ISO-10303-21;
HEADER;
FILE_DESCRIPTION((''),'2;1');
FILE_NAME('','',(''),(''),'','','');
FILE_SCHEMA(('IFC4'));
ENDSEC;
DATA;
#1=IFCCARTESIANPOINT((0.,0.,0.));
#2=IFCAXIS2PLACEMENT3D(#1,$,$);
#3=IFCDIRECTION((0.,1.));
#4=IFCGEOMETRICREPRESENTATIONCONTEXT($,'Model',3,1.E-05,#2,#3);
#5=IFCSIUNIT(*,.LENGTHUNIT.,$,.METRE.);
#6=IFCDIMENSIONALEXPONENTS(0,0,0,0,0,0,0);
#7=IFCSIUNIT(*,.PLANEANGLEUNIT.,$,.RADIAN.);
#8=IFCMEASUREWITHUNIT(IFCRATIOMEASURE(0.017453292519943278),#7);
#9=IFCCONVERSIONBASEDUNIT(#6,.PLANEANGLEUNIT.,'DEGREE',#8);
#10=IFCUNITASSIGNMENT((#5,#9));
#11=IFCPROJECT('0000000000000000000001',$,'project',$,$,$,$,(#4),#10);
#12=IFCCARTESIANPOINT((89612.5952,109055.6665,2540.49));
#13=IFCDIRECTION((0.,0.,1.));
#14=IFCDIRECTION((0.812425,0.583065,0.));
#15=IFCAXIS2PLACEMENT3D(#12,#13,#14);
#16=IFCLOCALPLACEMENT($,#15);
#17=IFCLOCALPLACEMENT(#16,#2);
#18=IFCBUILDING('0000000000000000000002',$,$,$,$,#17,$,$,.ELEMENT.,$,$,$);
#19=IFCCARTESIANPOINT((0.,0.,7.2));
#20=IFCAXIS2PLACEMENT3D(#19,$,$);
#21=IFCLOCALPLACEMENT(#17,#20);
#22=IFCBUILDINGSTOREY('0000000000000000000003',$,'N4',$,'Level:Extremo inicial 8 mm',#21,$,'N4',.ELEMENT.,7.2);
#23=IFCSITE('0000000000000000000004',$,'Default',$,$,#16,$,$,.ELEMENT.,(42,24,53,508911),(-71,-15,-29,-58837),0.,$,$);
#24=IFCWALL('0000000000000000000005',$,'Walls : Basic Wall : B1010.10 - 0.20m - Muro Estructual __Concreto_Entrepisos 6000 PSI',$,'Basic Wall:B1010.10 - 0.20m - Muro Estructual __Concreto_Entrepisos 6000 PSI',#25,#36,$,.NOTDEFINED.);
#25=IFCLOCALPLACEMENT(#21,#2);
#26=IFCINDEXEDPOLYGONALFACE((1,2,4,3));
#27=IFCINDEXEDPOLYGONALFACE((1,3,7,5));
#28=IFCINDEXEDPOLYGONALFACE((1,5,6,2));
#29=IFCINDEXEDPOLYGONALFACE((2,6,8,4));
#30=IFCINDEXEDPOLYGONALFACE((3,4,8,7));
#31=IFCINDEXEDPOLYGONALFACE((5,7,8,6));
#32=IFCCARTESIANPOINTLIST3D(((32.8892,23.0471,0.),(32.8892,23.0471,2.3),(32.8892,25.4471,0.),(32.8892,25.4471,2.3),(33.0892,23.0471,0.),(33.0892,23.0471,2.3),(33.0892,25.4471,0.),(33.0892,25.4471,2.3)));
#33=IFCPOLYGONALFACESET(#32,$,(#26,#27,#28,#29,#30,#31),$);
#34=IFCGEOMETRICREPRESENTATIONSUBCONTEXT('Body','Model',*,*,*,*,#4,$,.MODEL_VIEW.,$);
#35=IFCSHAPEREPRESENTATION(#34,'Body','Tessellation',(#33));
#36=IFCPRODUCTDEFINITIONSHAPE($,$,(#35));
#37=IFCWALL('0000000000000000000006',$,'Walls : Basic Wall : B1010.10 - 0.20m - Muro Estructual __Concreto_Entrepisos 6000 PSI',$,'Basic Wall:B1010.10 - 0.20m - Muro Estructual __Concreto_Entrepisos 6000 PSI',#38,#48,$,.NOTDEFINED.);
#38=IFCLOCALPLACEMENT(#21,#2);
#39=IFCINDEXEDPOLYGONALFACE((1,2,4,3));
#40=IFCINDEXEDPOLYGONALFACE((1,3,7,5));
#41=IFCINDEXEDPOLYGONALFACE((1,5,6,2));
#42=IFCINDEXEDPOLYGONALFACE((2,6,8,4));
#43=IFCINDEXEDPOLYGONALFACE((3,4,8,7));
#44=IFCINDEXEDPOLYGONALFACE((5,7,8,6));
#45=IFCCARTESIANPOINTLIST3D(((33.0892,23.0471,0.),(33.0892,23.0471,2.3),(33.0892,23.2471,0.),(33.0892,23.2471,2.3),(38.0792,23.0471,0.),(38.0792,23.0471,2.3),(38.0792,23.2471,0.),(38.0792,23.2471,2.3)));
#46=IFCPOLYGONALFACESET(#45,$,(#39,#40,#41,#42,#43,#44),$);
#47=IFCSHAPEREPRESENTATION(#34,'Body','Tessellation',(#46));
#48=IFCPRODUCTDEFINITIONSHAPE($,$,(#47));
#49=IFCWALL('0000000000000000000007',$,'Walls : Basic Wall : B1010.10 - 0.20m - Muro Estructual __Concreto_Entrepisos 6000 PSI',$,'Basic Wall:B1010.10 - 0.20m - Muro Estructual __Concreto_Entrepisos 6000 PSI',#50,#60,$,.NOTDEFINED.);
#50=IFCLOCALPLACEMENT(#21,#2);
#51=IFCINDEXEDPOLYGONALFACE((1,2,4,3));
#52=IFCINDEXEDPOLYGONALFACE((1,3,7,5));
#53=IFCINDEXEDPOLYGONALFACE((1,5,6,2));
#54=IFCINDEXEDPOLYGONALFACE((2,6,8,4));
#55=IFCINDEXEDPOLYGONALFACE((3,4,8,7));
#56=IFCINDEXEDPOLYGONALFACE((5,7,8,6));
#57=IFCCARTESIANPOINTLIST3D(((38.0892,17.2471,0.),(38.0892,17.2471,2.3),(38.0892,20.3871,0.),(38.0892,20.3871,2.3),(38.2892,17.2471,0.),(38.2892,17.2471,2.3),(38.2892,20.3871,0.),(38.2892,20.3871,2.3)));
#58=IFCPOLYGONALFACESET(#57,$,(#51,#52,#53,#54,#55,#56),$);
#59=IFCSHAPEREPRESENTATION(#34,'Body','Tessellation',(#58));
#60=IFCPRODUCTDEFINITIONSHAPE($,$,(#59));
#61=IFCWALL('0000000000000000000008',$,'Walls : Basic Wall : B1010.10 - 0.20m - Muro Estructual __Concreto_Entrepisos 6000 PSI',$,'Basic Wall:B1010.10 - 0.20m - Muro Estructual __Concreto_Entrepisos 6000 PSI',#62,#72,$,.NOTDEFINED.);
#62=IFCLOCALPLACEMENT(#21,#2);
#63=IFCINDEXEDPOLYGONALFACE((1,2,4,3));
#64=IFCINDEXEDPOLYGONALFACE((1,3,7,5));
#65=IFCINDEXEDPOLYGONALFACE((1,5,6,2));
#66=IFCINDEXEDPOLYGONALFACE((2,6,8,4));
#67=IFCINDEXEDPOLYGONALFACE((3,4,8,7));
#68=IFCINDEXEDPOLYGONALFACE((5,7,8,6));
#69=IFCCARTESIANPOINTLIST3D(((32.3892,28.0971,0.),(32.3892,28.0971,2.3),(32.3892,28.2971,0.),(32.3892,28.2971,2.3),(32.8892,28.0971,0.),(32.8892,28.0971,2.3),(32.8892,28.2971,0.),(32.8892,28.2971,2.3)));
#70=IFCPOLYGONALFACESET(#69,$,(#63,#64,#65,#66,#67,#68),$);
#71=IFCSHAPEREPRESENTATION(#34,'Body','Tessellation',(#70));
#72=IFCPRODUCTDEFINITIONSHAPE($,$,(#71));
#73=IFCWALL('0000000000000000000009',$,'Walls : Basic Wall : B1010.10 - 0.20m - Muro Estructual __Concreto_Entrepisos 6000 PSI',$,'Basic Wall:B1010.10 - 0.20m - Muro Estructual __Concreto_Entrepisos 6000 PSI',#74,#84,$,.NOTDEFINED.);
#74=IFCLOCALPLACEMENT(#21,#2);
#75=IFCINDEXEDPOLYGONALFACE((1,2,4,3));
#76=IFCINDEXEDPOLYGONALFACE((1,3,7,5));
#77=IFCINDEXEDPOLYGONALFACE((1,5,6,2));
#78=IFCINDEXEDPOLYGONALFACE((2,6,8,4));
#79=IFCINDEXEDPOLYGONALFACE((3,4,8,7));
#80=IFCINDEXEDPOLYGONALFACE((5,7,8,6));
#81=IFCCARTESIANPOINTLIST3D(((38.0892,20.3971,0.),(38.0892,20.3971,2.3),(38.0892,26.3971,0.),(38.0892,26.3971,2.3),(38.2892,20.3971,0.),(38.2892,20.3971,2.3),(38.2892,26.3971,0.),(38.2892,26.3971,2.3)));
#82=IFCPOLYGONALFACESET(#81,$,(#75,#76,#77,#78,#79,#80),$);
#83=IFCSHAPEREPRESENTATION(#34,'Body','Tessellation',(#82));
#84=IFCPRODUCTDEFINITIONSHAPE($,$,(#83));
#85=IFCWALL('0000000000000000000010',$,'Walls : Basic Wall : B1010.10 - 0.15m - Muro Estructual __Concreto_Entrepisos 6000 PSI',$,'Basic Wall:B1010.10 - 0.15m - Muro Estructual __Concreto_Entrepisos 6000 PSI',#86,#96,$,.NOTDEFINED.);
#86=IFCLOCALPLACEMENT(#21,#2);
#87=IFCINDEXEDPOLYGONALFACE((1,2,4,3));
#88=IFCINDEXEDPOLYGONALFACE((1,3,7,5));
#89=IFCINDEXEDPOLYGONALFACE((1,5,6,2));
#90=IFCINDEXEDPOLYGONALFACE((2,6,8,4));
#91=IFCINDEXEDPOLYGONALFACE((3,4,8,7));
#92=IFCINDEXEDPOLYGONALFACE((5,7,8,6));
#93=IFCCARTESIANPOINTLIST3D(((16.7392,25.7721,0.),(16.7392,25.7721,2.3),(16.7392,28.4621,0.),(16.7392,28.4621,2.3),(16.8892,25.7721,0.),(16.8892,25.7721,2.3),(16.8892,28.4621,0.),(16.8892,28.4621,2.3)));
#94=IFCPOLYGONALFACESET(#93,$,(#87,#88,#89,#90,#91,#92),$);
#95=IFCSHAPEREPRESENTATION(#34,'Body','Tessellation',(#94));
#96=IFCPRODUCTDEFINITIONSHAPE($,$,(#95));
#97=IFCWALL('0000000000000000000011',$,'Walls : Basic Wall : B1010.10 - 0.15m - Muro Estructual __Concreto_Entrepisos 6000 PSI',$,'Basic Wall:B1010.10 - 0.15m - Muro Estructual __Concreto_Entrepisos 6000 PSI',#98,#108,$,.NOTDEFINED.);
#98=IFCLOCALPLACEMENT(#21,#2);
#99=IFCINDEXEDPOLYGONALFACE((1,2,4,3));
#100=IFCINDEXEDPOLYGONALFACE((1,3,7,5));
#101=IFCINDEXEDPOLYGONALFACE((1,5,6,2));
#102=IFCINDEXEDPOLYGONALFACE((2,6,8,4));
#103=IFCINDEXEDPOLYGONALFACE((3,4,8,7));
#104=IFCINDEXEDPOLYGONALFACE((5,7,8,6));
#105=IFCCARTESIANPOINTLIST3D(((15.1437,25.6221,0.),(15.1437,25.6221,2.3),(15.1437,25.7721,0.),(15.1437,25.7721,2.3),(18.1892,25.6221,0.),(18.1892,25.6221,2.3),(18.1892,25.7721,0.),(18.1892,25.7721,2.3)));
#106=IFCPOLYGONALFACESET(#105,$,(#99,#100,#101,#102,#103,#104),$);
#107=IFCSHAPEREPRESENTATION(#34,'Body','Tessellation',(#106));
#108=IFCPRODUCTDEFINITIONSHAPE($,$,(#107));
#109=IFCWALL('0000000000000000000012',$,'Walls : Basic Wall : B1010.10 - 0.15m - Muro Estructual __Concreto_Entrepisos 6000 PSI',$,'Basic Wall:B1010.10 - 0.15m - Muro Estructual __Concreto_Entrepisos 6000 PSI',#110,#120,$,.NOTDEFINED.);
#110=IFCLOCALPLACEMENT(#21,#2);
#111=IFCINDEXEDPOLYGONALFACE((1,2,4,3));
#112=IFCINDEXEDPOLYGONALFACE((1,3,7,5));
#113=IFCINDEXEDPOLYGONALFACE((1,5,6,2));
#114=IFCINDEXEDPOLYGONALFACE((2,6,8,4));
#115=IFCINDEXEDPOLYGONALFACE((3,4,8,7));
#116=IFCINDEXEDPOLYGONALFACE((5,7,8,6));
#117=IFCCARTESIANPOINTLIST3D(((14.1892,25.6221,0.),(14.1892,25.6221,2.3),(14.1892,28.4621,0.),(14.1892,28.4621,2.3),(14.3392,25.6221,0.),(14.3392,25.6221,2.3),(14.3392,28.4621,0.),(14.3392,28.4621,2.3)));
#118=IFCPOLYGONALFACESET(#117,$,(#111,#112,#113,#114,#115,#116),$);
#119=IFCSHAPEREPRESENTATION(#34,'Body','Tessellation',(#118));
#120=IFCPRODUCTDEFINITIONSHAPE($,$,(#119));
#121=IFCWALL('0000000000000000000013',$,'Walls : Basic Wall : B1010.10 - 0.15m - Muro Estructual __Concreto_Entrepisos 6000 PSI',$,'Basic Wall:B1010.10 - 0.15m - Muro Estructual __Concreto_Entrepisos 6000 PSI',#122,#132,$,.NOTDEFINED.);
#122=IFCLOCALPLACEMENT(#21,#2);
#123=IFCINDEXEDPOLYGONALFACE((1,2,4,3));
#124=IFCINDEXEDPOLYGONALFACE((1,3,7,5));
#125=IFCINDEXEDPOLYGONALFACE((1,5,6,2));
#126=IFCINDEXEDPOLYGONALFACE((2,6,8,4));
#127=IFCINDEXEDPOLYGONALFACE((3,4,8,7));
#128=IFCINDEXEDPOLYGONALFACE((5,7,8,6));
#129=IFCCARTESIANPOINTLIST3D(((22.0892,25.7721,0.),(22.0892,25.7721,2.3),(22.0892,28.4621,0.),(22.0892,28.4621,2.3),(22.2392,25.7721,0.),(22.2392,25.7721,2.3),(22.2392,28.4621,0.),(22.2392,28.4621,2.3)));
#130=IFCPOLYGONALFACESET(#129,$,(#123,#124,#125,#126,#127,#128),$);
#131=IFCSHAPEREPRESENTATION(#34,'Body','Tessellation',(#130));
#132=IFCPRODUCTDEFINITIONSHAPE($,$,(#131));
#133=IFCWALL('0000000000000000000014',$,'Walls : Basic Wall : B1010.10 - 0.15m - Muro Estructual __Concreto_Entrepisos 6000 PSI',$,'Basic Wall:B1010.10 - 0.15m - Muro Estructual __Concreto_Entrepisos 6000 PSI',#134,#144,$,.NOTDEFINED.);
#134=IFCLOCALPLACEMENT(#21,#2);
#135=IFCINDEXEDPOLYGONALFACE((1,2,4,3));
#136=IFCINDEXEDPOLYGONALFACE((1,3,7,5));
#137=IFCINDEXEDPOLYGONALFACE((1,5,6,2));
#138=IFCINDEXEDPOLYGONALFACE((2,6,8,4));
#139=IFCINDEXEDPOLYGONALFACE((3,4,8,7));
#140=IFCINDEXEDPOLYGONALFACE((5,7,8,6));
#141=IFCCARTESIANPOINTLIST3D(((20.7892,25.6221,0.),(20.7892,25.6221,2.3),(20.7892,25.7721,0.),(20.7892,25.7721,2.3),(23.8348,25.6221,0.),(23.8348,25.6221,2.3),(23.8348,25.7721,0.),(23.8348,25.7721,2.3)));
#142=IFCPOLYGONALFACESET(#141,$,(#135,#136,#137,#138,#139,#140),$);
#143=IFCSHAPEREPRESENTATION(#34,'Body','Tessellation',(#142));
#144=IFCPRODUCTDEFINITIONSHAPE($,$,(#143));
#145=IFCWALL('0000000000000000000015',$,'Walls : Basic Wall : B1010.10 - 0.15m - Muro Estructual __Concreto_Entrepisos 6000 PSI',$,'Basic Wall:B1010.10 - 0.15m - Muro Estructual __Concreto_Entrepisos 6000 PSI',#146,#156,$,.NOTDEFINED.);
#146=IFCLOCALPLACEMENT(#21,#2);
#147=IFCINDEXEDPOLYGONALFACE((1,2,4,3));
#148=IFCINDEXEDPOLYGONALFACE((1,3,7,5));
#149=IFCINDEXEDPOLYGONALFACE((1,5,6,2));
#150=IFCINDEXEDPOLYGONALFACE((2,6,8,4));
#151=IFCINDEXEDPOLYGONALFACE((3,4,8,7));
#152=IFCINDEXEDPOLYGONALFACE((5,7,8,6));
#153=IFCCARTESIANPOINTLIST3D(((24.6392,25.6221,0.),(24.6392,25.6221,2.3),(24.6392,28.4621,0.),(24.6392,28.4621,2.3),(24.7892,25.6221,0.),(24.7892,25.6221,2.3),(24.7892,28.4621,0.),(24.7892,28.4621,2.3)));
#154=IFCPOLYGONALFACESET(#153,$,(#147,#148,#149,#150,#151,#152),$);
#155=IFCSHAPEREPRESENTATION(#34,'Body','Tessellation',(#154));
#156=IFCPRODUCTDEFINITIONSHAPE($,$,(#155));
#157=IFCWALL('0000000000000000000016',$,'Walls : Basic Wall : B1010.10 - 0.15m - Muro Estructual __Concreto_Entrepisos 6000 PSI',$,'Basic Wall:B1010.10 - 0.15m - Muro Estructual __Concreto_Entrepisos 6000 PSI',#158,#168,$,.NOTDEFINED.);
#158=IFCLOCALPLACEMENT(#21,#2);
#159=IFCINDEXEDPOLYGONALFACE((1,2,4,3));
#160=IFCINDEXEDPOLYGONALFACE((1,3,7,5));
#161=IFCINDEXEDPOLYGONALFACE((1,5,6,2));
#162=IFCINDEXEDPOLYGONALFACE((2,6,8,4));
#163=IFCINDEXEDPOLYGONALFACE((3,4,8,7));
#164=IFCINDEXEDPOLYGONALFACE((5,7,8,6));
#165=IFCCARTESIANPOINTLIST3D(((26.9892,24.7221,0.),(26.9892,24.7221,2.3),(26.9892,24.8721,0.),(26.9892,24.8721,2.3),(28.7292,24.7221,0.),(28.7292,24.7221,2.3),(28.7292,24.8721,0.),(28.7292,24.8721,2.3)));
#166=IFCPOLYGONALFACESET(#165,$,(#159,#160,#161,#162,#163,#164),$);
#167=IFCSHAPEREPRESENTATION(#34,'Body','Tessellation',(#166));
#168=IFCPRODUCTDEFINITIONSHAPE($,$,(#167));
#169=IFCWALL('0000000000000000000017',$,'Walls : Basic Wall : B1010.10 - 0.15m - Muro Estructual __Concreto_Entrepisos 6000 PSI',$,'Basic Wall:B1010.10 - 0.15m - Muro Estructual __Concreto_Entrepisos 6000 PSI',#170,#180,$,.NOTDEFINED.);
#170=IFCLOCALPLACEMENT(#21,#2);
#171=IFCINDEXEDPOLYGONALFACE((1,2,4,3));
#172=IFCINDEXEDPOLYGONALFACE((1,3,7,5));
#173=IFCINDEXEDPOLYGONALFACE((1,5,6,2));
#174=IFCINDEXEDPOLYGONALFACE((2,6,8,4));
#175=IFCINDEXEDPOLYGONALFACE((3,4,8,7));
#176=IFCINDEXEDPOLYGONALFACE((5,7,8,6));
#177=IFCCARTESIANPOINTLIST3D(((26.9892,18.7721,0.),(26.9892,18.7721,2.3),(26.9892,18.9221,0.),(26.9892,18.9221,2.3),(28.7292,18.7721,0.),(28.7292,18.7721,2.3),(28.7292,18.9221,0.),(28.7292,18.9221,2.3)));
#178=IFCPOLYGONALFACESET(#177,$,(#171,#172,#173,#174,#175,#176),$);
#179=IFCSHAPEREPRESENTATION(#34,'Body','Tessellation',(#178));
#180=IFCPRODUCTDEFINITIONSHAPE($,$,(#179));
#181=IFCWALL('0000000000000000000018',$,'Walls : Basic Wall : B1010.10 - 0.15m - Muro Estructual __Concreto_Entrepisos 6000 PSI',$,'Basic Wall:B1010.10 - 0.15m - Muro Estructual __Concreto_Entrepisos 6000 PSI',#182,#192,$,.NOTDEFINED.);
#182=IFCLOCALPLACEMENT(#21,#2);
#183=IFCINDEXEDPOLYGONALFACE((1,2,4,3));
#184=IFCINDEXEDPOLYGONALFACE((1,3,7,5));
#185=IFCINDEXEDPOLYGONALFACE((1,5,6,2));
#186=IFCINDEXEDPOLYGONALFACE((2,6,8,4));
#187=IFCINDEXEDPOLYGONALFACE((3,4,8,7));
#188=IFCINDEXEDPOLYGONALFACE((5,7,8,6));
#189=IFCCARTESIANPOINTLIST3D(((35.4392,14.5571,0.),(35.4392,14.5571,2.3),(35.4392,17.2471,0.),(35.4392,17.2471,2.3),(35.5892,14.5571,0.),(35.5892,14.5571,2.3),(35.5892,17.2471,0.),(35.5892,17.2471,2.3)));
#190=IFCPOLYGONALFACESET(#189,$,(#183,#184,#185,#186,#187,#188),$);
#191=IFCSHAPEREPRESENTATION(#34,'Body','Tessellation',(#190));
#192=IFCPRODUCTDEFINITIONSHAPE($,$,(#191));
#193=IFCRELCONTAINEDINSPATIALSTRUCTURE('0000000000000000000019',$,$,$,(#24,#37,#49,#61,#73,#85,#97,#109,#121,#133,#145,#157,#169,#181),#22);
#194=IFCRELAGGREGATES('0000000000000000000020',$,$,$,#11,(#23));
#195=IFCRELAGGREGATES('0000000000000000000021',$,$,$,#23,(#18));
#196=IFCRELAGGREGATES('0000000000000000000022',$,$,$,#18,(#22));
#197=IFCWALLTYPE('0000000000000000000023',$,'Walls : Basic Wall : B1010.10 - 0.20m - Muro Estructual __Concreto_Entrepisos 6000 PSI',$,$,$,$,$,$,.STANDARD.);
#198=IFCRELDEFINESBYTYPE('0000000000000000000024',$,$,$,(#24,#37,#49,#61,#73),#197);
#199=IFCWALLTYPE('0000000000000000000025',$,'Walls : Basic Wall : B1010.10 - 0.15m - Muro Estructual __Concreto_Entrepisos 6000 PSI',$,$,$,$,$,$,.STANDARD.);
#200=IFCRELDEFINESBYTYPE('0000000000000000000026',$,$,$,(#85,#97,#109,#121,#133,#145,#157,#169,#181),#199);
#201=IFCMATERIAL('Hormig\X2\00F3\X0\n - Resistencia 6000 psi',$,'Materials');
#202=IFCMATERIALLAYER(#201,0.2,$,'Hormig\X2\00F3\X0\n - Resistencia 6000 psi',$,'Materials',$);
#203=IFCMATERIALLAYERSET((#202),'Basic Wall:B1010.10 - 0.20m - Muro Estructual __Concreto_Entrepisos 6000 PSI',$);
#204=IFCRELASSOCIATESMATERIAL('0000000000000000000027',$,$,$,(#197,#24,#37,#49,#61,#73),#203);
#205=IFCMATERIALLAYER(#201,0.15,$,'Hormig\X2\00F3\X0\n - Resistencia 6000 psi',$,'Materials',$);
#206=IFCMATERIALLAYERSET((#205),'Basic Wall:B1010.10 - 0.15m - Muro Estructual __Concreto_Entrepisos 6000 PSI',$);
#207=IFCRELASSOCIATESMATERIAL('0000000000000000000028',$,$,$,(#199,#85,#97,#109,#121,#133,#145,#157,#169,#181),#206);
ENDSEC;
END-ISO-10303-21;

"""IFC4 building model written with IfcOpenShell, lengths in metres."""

from ifc_helpers import new_model, entity, si_unit, converted_unit, direction, frame, frame_2d, origin, place, context, subcontext, project, spatial, rectangle, extrude, material, layer, layer_set, layer_usage, type_object, element, save


model = new_model("IFC4")

# Units and contexts
model_context = context("Model", 3, precision=1e-05, world=origin(), true_north=direction((0.0, 1.0)))
body_context = subcontext(model_context, "Body", "Model", "MODEL_VIEW")
ifc_project = project(units=[si_unit("LENGTHUNIT", "METRE"), converted_unit("PLANEANGLEUNIT", "DEGREE", entity("IfcRatioMeasure", 0.017453292519943278), si_unit("PLANEANGLEUNIT", "RADIAN"), dimensions=[0, 0, 0, 0, 0, 0, 0])], contexts=[model_context])

# Site, building, storey
site_placement = place(None, frame((89612.5952, 109055.6665, 2540.49), z_axis=(0.0, 0.0, 1.0), x_axis=(0.812425, 0.583065, 0.0)))
site = spatial("IfcSite", under=ifc_project, at=site_placement, Name="Default", CompositionType="ELEMENT", RefLatitude=(42, 24, 53, 508911), RefLongitude=(-71, -15, -29, -58837), RefElevation=0.0)
building_placement = place(site_placement, origin())
building = spatial("IfcBuilding", under=site, at=building_placement, CompositionType="ELEMENT")
storey_placement = place(building_placement, frame((0.0, 0.0, 7.2)))
storey = spatial("IfcBuildingStorey", under=building, at=storey_placement, Name="N4", ObjectType="Level:Extremo inicial 8 mm", LongName="N4", CompositionType="ELEMENT", Elevation=7.2)

# Walls
ifc_material = material(Name="Hormigón - Resistencia 6000 psi", Category="Materials")
ifc_layer_1 = layer(ifc_material, 0.2, Name="Hormigón - Resistencia 6000 psi", Category="Materials")
ifc_layer_set_1 = layer_set([ifc_layer_1], Name="Basic Wall:B1010.10 - 0.20m - Muro Estructual __Concreto_Entrepisos 6000 PSI")
wall_type_1 = type_object("IfcWallType", Name="Walls : Basic Wall : B1010.10 - 0.20m - Muro Estructual __Concreto_Entrepisos 6000 PSI", PredefinedType="STANDARD", material=ifc_layer_set_1)
ifc_layer_usage_1 = layer_usage(ifc_layer_set_1, "AXIS2", "POSITIVE", -0.1)
wall_1_placement = place(storey_placement, frame((32.9892, 25.4471, 0.0), z_axis=(0.0, 0.0, 1.0), x_axis=(0.0, -1.0, 0.0)))
element("IfcWall", 1, at=wall_1_placement, inside=storey, type_object=wall_type_1, material=ifc_layer_usage_1, Name="Walls : Basic Wall : B1010.10 - 0.20m - Muro Estructual __Concreto_Entrepisos 6000 PSI", ObjectType="Basic Wall:B1010.10 - 0.20m - Muro Estructual __Concreto_Entrepisos 6000 PSI", PredefinedType="NOTDEFINED", context=body_context, shape_type="SweptSolid", body=[
    extrude(rectangle(XDim=2.4, YDim=0.2, at=frame_2d((1.2, 0.0), x_axis=(-1.0, 0.0))), origin(), (0.0, 0.0, 1.0), 2.3),
])
ifc_layer_usage_2 = layer_usage(ifc_layer_set_1, "AXIS2", "POSITIVE", -0.1)
wall_2_placement = place(storey_placement, frame((33.0892, 23.1471, 0.0)))
element("IfcWall", 2, at=wall_2_placement, inside=storey, type_object=wall_type_1, material=ifc_layer_usage_2, Name="Walls : Basic Wall : B1010.10 - 0.20m - Muro Estructual __Concreto_Entrepisos 6000 PSI", ObjectType="Basic Wall:B1010.10 - 0.20m - Muro Estructual __Concreto_Entrepisos 6000 PSI", PredefinedType="NOTDEFINED", context=body_context, shape_type="SweptSolid", body=[
    extrude(rectangle(XDim=4.99, YDim=0.2, at=frame_2d((2.495, 0.0), x_axis=(-1.0, 0.0))), origin(), (0.0, 0.0, 1.0), 2.3),
])
ifc_layer_usage_3 = layer_usage(ifc_layer_set_1, "AXIS2", "POSITIVE", -0.1)
wall_3_placement = place(storey_placement, frame((38.1892, 17.2471, 0.0), z_axis=(0.0, 0.0, 1.0), x_axis=(0.0, 1.0, 0.0)))
element("IfcWall", 3, at=wall_3_placement, inside=storey, type_object=wall_type_1, material=ifc_layer_usage_3, Name="Walls : Basic Wall : B1010.10 - 0.20m - Muro Estructual __Concreto_Entrepisos 6000 PSI", ObjectType="Basic Wall:B1010.10 - 0.20m - Muro Estructual __Concreto_Entrepisos 6000 PSI", PredefinedType="NOTDEFINED", context=body_context, shape_type="SweptSolid", body=[
    extrude(rectangle(XDim=3.14, YDim=0.2, at=frame_2d((1.57, 0.0), x_axis=(-1.0, 0.0))), origin(), (0.0, 0.0, 1.0), 2.3),
])
ifc_layer_usage_4 = layer_usage(ifc_layer_set_1, "AXIS2", "POSITIVE", -0.1)
wall_4_placement = place(storey_placement, frame((32.3892, 28.1971, 0.0)))
element("IfcWall", 4, at=wall_4_placement, inside=storey, type_object=wall_type_1, material=ifc_layer_usage_4, Name="Walls : Basic Wall : B1010.10 - 0.20m - Muro Estructual __Concreto_Entrepisos 6000 PSI", ObjectType="Basic Wall:B1010.10 - 0.20m - Muro Estructual __Concreto_Entrepisos 6000 PSI", PredefinedType="NOTDEFINED", context=body_context, shape_type="SweptSolid", body=[
    extrude(rectangle(XDim=0.5, YDim=0.2, at=frame_2d((0.25, 0.0), x_axis=(-1.0, 0.0))), origin(), (0.0, 0.0, 1.0), 2.3),
])
ifc_layer_usage_5 = layer_usage(ifc_layer_set_1, "AXIS2", "POSITIVE", -0.1)
wall_5_placement = place(storey_placement, frame((38.1892, 20.3971, 0.0), z_axis=(0.0, 0.0, 1.0), x_axis=(0.0, 1.0, 0.0)))
element("IfcWall", 5, at=wall_5_placement, inside=storey, type_object=wall_type_1, material=ifc_layer_usage_5, Name="Walls : Basic Wall : B1010.10 - 0.20m - Muro Estructual __Concreto_Entrepisos 6000 PSI", ObjectType="Basic Wall:B1010.10 - 0.20m - Muro Estructual __Concreto_Entrepisos 6000 PSI", PredefinedType="NOTDEFINED", context=body_context, shape_type="SweptSolid", body=[
    extrude(rectangle(XDim=6.0, YDim=0.2, at=frame_2d((3.0, 0.0), x_axis=(-1.0, 0.0))), origin(), (0.0, 0.0, 1.0), 2.3),
])
ifc_layer_2 = layer(ifc_material, 0.15, Name="Hormigón - Resistencia 6000 psi", Category="Materials")
ifc_layer_set_2 = layer_set([ifc_layer_2], Name="Basic Wall:B1010.10 - 0.15m - Muro Estructual __Concreto_Entrepisos 6000 PSI")
ifc_layer_usage_6 = layer_usage(ifc_layer_set_2, "AXIS2", "POSITIVE", -0.075)
wall_type_2 = type_object("IfcWallType", Name="Walls : Basic Wall : B1010.10 - 0.15m - Muro Estructual __Concreto_Entrepisos 6000 PSI", PredefinedType="STANDARD", material=ifc_layer_set_2)
wall_6_placement = place(storey_placement, frame((16.8142, 28.4621, 0.0), z_axis=(0.0, 0.0, 1.0), x_axis=(0.0, -1.0, 0.0)))
element("IfcWall", 6, at=wall_6_placement, inside=storey, type_object=wall_type_2, material=ifc_layer_usage_6, Name="Walls : Basic Wall : B1010.10 - 0.15m - Muro Estructual __Concreto_Entrepisos 6000 PSI", ObjectType="Basic Wall:B1010.10 - 0.15m - Muro Estructual __Concreto_Entrepisos 6000 PSI", PredefinedType="NOTDEFINED", context=body_context, shape_type="SweptSolid", body=[
    extrude(rectangle(XDim=2.69, YDim=0.15, at=frame_2d((1.345, 0.0), x_axis=(-1.0, 0.0))), origin(), (0.0, 0.0, 1.0), 2.3),
])
ifc_layer_usage_7 = layer_usage(ifc_layer_set_2, "AXIS2", "POSITIVE", -0.075)
wall_7_placement = place(storey_placement, frame((18.1892, 25.6971, 0.0), z_axis=(0.0, 0.0, 1.0), x_axis=(-1.0, 0.0, 0.0)))
element("IfcWall", 7, at=wall_7_placement, inside=storey, type_object=wall_type_2, material=ifc_layer_usage_7, Name="Walls : Basic Wall : B1010.10 - 0.15m - Muro Estructual __Concreto_Entrepisos 6000 PSI", ObjectType="Basic Wall:B1010.10 - 0.15m - Muro Estructual __Concreto_Entrepisos 6000 PSI", PredefinedType="NOTDEFINED", context=body_context, shape_type="SweptSolid", body=[
    extrude(rectangle(XDim=3.0455, YDim=0.15, at=frame_2d((1.5228, 0.0), x_axis=(-1.0, 0.0))), origin(), (0.0, 0.0, 1.0), 2.3),
])
ifc_layer_usage_8 = layer_usage(ifc_layer_set_2, "AXIS2", "POSITIVE", -0.075)
wall_8_placement = place(storey_placement, frame((14.2642, 28.4621, 0.0), z_axis=(0.0, 0.0, 1.0), x_axis=(0.0, -1.0, 0.0)))
element("IfcWall", 8, at=wall_8_placement, inside=storey, type_object=wall_type_2, material=ifc_layer_usage_8, Name="Walls : Basic Wall : B1010.10 - 0.15m - Muro Estructual __Concreto_Entrepisos 6000 PSI", ObjectType="Basic Wall:B1010.10 - 0.15m - Muro Estructual __Concreto_Entrepisos 6000 PSI", PredefinedType="NOTDEFINED", context=body_context, shape_type="SweptSolid", body=[
    extrude(rectangle(XDim=2.84, YDim=0.15, at=frame_2d((1.42, 0.0), x_axis=(-1.0, 0.0))), origin(), (0.0, 0.0, 1.0), 2.3),
])
ifc_layer_usage_9 = layer_usage(ifc_layer_set_2, "AXIS2", "NEGATIVE", 0.075)
wall_9_placement = place(storey_placement, frame((22.1642, 28.4621, 0.0), z_axis=(0.0, 0.0, 1.0), x_axis=(0.0, -1.0, 0.0)))
element("IfcWall", 9, at=wall_9_placement, inside=storey, type_object=wall_type_2, material=ifc_layer_usage_9, Name="Walls : Basic Wall : B1010.10 - 0.15m - Muro Estructual __Concreto_Entrepisos 6000 PSI", ObjectType="Basic Wall:B1010.10 - 0.15m - Muro Estructual __Concreto_Entrepisos 6000 PSI", PredefinedType="NOTDEFINED", context=body_context, shape_type="SweptSolid", body=[
    extrude(rectangle(XDim=2.69, YDim=0.15, at=frame_2d((1.345, 0.0), x_axis=(-1.0, 0.0))), origin(), (0.0, 0.0, 1.0), 2.3),
])
ifc_layer_usage_10 = layer_usage(ifc_layer_set_2, "AXIS2", "NEGATIVE", 0.075)
wall_10_placement = place(storey_placement, frame((20.7892, 25.6971, 0.0)))
element("IfcWall", 10, at=wall_10_placement, inside=storey, type_object=wall_type_2, material=ifc_layer_usage_10, Name="Walls : Basic Wall : B1010.10 - 0.15m - Muro Estructual __Concreto_Entrepisos 6000 PSI", ObjectType="Basic Wall:B1010.10 - 0.15m - Muro Estructual __Concreto_Entrepisos 6000 PSI", PredefinedType="NOTDEFINED", context=body_context, shape_type="SweptSolid", body=[
    extrude(rectangle(XDim=3.0455, YDim=0.15, at=frame_2d((1.5228, 0.0), x_axis=(-1.0, 0.0))), origin(), (0.0, 0.0, 1.0), 2.3),
])
ifc_layer_usage_11 = layer_usage(ifc_layer_set_2, "AXIS2", "NEGATIVE", 0.075)
wall_11_placement = place(storey_placement, frame((24.7142, 28.4621, 0.0), z_axis=(0.0, 0.0, 1.0), x_axis=(0.0, -1.0, 0.0)))
element("IfcWall", 11, at=wall_11_placement, inside=storey, type_object=wall_type_2, material=ifc_layer_usage_11, Name="Walls : Basic Wall : B1010.10 - 0.15m - Muro Estructual __Concreto_Entrepisos 6000 PSI", ObjectType="Basic Wall:B1010.10 - 0.15m - Muro Estructual __Concreto_Entrepisos 6000 PSI", PredefinedType="NOTDEFINED", context=body_context, shape_type="SweptSolid", body=[
    extrude(rectangle(XDim=2.84, YDim=0.15, at=frame_2d((1.42, 0.0), x_axis=(-1.0, 0.0))), origin(), (0.0, 0.0, 1.0), 2.3),
])
ifc_layer_usage_12 = layer_usage(ifc_layer_set_2, "AXIS2", "NEGATIVE", 0.075)
wall_12_placement = place(storey_placement, frame((26.9892, 24.7971, 0.0)))
element("IfcWall", 12, at=wall_12_placement, inside=storey, type_object=wall_type_2, material=ifc_layer_usage_12, Name="Walls : Basic Wall : B1010.10 - 0.15m - Muro Estructual __Concreto_Entrepisos 6000 PSI", ObjectType="Basic Wall:B1010.10 - 0.15m - Muro Estructual __Concreto_Entrepisos 6000 PSI", PredefinedType="NOTDEFINED", context=body_context, shape_type="SweptSolid", body=[
    extrude(rectangle(XDim=1.74, YDim=0.15, at=frame_2d((0.87, 0.0), x_axis=(-1.0, 0.0))), origin(), (0.0, 0.0, 1.0), 2.3),
])
ifc_layer_usage_13 = layer_usage(ifc_layer_set_2, "AXIS2", "POSITIVE", -0.075)
wall_13_placement = place(storey_placement, frame((26.9892, 18.8471, 0.0)))
element("IfcWall", 13, at=wall_13_placement, inside=storey, type_object=wall_type_2, material=ifc_layer_usage_13, Name="Walls : Basic Wall : B1010.10 - 0.15m - Muro Estructual __Concreto_Entrepisos 6000 PSI", ObjectType="Basic Wall:B1010.10 - 0.15m - Muro Estructual __Concreto_Entrepisos 6000 PSI", PredefinedType="NOTDEFINED", context=body_context, shape_type="SweptSolid", body=[
    extrude(rectangle(XDim=1.74, YDim=0.15, at=frame_2d((0.87, 0.0), x_axis=(-1.0, 0.0))), origin(), (0.0, 0.0, 1.0), 2.3),
])
ifc_layer_usage_14 = layer_usage(ifc_layer_set_2, "AXIS2", "NEGATIVE", 0.075)
wall_14_placement = place(storey_placement, frame((35.5142, 14.5571, 0.0), z_axis=(0.0, 0.0, 1.0), x_axis=(0.0, 1.0, 0.0)))
element("IfcWall", 14, at=wall_14_placement, inside=storey, type_object=wall_type_2, material=ifc_layer_usage_14, Name="Walls : Basic Wall : B1010.10 - 0.15m - Muro Estructual __Concreto_Entrepisos 6000 PSI", ObjectType="Basic Wall:B1010.10 - 0.15m - Muro Estructual __Concreto_Entrepisos 6000 PSI", PredefinedType="NOTDEFINED", context=body_context, shape_type="SweptSolid", body=[
    extrude(rectangle(XDim=2.69, YDim=0.15, at=frame_2d((1.345, 0.0), x_axis=(-1.0, 0.0))), origin(), (0.0, 0.0, 1.0), 2.3),
])

save(model, "model.ifc")
